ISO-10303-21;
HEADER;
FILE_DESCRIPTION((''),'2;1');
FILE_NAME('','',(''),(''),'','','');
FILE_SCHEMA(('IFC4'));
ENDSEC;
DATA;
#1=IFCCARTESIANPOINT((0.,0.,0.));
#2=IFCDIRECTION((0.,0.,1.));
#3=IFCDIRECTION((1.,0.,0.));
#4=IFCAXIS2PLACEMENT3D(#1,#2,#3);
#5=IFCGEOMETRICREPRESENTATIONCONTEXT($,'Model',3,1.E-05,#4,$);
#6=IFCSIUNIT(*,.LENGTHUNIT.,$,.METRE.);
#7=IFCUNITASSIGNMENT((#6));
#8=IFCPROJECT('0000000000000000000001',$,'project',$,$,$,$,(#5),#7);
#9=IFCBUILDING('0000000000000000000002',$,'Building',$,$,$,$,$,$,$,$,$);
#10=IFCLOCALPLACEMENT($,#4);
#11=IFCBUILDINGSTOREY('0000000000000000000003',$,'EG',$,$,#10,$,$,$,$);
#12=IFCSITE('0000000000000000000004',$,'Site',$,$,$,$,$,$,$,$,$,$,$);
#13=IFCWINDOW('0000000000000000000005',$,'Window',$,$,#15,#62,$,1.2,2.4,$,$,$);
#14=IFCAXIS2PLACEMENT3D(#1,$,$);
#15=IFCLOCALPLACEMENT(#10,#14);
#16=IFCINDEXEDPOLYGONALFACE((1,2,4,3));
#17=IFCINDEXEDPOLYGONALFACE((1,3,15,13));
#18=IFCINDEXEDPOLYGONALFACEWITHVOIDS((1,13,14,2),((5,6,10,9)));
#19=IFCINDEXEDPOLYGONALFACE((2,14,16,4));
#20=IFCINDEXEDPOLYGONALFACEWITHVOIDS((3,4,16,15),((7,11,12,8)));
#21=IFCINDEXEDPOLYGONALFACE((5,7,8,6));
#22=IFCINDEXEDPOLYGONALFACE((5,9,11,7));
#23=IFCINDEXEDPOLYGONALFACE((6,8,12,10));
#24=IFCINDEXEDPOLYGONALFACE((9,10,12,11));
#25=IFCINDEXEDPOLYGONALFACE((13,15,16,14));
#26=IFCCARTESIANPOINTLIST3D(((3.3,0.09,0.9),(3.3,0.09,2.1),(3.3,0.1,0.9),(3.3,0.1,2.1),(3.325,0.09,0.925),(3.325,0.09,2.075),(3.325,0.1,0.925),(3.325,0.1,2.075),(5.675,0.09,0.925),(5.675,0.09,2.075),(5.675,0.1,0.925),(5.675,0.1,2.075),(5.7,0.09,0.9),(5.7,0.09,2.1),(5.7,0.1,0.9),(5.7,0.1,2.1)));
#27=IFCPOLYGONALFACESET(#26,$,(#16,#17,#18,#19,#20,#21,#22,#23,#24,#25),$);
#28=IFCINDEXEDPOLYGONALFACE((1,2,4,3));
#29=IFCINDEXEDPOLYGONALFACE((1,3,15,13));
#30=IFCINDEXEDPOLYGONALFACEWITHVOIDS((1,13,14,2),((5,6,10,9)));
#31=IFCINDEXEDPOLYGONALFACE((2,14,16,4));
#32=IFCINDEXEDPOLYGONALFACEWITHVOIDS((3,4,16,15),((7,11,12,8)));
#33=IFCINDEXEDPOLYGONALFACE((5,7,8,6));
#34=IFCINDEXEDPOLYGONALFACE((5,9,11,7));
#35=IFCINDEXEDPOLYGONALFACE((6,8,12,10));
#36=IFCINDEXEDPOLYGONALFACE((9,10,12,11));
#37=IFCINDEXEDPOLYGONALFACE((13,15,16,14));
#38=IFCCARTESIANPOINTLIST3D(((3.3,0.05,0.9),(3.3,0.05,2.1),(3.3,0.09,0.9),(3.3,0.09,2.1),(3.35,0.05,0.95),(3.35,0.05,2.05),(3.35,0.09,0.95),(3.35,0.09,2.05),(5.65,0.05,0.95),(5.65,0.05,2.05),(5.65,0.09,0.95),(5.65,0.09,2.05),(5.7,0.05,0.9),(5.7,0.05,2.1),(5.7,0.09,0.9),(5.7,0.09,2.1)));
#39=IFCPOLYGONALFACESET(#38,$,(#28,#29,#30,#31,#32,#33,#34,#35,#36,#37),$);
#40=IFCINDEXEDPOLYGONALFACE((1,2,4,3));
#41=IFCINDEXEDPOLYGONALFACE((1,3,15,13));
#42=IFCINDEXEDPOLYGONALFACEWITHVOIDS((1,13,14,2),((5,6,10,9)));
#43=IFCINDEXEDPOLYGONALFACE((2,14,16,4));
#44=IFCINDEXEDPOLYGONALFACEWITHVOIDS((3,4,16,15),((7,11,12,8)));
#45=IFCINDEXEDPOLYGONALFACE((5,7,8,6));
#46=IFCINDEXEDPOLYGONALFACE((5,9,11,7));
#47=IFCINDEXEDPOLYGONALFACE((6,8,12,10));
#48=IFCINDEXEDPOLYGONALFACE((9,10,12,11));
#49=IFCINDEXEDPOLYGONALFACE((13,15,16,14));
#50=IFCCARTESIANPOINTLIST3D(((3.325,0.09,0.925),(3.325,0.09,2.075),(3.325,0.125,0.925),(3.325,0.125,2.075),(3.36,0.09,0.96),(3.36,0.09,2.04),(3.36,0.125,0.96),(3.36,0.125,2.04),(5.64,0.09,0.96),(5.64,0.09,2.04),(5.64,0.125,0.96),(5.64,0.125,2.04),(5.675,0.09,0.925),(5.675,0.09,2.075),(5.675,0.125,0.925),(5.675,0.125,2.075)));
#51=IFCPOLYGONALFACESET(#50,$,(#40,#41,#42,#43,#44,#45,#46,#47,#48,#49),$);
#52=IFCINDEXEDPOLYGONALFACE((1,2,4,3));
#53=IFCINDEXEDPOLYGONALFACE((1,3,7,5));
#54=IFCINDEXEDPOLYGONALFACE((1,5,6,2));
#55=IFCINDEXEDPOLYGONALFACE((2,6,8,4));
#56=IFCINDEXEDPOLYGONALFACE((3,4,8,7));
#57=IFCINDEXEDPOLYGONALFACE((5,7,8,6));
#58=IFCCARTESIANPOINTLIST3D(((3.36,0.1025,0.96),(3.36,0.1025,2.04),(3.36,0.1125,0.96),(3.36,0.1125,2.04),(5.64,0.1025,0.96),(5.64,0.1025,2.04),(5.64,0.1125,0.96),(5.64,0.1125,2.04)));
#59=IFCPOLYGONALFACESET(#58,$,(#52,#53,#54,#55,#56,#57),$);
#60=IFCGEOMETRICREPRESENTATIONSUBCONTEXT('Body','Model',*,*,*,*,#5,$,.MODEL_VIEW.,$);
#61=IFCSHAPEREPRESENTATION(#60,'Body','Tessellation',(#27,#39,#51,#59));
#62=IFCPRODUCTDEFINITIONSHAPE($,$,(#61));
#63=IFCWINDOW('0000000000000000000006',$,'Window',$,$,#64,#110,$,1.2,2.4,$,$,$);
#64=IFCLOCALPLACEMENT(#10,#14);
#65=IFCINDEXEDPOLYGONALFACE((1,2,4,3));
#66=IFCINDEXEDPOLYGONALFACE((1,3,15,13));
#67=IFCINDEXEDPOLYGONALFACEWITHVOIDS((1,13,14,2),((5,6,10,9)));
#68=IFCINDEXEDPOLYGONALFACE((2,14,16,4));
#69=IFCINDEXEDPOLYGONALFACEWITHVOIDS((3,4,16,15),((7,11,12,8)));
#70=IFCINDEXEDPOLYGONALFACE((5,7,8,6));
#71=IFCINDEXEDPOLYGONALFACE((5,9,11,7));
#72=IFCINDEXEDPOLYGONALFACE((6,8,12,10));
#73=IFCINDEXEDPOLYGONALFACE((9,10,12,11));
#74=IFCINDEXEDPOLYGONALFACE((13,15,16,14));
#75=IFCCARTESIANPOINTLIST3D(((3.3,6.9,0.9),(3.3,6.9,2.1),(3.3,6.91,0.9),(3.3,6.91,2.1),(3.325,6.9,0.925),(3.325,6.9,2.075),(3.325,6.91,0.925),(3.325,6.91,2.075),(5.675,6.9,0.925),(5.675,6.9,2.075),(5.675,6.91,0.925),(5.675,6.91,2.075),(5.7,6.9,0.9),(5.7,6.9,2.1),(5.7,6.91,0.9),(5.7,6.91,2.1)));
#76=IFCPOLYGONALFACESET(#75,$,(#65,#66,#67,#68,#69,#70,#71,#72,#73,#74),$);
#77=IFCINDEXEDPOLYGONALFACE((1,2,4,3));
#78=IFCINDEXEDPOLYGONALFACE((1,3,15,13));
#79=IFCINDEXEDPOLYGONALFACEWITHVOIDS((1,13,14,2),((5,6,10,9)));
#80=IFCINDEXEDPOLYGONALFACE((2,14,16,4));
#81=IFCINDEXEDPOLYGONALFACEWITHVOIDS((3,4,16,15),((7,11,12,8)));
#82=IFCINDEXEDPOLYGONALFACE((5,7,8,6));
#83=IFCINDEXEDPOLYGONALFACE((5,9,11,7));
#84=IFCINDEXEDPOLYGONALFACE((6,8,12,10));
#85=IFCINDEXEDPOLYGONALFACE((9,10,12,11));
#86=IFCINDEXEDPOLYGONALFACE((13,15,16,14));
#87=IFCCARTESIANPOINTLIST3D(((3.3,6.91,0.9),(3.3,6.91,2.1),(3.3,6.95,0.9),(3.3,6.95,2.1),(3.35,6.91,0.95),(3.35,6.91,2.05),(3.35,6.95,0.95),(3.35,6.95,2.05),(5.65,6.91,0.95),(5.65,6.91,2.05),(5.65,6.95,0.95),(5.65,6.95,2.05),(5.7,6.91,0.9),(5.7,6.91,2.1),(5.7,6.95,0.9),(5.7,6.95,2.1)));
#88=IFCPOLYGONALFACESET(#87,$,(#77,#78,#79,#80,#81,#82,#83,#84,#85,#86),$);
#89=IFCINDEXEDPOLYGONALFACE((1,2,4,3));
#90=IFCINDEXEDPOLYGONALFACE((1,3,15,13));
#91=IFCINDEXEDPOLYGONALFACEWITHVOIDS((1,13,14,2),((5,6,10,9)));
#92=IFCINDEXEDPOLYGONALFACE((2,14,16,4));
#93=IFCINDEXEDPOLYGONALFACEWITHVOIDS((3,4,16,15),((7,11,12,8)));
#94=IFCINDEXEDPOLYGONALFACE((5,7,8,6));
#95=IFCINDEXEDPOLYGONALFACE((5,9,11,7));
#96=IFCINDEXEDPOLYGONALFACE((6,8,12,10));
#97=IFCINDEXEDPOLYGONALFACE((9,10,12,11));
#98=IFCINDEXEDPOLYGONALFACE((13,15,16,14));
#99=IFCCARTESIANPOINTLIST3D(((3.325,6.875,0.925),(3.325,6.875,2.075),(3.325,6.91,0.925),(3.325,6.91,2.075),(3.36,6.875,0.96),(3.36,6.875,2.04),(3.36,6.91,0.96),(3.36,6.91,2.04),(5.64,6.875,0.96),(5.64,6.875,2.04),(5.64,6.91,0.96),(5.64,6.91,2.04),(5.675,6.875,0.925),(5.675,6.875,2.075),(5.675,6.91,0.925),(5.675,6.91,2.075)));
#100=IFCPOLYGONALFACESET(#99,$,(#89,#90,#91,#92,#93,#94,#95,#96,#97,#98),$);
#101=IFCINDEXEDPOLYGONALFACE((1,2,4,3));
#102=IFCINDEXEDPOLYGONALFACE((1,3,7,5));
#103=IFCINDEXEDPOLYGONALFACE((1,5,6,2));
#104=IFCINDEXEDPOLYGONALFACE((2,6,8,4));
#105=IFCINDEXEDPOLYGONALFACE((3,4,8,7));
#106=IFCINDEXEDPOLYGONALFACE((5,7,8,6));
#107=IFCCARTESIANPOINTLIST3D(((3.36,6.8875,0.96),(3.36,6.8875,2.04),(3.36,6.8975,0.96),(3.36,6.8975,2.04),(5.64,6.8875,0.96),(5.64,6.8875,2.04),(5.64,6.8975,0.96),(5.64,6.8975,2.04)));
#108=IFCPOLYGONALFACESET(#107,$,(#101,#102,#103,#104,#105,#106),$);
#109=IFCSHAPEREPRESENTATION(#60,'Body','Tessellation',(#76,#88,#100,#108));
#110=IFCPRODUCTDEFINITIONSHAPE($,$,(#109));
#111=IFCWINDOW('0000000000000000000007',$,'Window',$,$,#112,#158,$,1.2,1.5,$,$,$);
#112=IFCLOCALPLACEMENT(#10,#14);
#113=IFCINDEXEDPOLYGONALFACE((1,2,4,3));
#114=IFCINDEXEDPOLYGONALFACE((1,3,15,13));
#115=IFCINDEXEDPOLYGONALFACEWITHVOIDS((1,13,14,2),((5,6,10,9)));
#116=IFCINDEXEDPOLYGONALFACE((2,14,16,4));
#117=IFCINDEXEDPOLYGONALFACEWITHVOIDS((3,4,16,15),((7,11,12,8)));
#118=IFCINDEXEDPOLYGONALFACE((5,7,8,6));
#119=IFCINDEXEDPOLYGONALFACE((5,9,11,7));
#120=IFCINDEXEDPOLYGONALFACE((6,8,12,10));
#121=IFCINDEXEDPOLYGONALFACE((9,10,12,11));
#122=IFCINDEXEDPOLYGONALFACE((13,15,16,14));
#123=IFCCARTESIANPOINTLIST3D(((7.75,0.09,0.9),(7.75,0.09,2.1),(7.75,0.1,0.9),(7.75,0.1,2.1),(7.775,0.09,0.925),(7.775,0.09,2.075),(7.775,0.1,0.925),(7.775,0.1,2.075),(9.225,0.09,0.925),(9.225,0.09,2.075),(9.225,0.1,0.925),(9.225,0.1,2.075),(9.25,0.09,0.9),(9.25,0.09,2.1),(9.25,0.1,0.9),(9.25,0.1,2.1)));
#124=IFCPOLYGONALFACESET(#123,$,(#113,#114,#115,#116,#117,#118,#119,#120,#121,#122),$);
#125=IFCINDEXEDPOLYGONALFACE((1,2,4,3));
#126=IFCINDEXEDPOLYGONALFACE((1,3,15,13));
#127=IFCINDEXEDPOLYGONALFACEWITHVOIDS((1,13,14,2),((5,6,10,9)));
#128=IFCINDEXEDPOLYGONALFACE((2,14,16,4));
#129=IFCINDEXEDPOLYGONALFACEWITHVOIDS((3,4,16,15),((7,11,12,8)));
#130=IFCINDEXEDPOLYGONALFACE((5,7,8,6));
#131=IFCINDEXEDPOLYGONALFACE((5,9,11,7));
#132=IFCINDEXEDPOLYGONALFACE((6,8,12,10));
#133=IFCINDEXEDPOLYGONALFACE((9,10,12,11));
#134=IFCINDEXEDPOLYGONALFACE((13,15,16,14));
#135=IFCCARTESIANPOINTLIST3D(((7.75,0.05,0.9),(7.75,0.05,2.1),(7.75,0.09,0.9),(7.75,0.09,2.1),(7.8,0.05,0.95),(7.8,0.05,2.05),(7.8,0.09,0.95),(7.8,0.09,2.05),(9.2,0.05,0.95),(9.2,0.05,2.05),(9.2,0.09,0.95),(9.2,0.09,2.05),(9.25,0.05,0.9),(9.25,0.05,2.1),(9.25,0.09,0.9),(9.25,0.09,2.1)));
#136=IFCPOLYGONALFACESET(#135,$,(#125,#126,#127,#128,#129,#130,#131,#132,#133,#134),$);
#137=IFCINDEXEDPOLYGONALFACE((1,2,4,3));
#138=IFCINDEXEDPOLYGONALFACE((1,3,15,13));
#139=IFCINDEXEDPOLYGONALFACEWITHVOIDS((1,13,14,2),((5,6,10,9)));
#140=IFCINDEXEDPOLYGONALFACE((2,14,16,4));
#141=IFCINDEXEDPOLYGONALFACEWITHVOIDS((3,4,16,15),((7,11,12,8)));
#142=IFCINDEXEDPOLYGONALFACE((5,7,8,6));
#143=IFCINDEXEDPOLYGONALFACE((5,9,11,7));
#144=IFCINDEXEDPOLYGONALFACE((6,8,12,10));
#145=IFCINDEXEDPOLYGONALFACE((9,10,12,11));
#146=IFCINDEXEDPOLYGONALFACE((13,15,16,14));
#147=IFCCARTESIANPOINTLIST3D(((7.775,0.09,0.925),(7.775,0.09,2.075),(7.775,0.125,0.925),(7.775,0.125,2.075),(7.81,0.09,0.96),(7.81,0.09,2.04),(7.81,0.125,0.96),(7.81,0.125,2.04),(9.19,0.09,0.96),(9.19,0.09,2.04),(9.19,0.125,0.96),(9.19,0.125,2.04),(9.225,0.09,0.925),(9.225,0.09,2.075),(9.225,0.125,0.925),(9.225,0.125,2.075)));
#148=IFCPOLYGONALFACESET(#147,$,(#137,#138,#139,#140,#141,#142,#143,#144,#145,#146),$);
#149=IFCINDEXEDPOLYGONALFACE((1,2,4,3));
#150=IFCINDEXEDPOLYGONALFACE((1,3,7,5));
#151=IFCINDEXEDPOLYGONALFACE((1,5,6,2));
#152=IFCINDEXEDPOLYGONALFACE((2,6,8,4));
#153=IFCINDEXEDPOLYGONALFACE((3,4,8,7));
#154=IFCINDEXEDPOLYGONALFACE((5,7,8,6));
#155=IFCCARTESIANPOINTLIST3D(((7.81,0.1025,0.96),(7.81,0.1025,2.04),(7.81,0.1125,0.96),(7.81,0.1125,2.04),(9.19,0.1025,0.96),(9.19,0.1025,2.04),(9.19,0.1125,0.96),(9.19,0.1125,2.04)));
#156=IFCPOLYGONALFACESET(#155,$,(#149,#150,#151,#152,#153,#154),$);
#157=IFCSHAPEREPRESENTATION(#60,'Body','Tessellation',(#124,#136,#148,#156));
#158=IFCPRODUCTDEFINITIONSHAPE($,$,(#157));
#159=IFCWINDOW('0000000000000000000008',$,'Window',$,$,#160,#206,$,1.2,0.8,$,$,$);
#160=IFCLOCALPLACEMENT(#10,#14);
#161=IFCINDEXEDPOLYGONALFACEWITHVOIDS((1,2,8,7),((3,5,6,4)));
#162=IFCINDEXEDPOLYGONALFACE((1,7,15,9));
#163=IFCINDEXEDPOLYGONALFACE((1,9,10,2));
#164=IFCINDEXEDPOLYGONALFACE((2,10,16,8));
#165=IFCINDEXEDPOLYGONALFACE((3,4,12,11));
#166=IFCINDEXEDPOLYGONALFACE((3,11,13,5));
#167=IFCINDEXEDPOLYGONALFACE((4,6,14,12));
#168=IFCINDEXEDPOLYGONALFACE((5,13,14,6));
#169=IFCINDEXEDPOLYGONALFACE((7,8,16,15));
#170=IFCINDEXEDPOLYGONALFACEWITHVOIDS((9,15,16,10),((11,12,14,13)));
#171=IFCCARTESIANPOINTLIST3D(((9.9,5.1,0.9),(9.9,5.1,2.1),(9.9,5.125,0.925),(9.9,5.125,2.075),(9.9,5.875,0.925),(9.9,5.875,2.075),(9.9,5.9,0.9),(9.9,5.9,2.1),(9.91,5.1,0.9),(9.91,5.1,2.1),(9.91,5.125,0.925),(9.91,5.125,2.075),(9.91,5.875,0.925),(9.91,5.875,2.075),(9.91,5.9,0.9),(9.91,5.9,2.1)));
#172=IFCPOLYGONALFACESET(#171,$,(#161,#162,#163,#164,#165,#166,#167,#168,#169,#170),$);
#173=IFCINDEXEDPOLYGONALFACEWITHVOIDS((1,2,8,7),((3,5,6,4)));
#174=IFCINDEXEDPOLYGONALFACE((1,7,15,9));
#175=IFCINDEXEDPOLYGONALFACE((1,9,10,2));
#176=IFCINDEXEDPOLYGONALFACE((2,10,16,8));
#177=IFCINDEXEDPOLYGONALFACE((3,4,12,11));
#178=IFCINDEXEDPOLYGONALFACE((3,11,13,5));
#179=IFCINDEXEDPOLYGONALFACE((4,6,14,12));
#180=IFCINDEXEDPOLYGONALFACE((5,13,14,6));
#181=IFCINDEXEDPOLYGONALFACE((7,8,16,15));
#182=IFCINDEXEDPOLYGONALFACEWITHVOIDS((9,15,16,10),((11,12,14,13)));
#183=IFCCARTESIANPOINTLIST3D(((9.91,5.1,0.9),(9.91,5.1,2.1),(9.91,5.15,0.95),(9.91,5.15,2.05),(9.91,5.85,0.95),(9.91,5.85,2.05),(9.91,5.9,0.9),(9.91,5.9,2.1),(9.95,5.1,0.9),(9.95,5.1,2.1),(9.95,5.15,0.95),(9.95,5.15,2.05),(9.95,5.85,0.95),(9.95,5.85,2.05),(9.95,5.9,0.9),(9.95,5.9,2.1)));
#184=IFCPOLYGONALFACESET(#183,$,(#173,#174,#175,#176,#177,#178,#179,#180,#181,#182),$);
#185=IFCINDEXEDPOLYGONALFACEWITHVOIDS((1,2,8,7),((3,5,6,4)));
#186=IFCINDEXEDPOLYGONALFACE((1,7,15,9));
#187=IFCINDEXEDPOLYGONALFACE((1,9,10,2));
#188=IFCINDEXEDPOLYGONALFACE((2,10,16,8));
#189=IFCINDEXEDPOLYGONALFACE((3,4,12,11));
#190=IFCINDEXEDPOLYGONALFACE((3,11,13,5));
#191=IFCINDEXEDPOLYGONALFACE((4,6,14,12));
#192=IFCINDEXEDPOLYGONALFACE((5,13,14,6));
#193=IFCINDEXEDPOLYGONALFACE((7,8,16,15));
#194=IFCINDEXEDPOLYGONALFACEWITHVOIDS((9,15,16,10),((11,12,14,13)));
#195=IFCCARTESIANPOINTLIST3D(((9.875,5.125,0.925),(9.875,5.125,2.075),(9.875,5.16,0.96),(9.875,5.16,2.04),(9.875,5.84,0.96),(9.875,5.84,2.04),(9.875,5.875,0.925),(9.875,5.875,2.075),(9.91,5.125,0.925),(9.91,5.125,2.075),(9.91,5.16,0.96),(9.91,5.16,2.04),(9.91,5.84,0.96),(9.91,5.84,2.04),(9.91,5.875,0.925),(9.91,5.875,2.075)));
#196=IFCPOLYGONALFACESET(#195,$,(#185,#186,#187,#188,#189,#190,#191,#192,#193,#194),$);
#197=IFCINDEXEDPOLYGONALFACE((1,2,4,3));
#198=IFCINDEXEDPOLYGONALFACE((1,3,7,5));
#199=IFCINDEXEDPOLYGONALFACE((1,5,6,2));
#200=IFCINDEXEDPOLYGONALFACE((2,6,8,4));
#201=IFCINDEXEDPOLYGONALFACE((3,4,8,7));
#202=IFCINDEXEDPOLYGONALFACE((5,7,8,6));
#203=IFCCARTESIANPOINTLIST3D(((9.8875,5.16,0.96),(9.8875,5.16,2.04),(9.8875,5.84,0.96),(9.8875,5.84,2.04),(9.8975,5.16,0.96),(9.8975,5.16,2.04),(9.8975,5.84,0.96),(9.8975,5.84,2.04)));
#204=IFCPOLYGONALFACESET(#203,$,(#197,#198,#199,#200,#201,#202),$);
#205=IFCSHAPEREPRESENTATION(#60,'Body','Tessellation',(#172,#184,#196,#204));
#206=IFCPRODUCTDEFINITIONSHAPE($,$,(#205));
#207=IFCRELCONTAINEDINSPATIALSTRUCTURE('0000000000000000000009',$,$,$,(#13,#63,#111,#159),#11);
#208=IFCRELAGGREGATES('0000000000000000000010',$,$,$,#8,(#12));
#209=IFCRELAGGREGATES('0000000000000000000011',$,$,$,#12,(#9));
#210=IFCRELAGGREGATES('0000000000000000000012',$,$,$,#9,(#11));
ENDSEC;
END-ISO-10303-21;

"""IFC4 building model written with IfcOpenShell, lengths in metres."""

from ifc_helpers import new_model, si_unit, frame, origin_with_axes, place, context, subcontext, project, spatial, line, indexed_curve, outline, extrude, element, save


model = new_model("IFC4")

# Units and contexts
model_context = context("Model", 3, precision=1e-05, world=origin_with_axes())
body_context = subcontext(model_context, "Body", "Model", "MODEL_VIEW")
ifc_project = project(units=[si_unit("LENGTHUNIT", "METRE")], contexts=[model_context])

# Site, building, storey
site = spatial("IfcSite", under=ifc_project, Name="Site")
building = spatial("IfcBuilding", under=site, Name="Building")
storey_placement = place(None, origin_with_axes())
storey = spatial("IfcBuildingStorey", under=building, at=storey_placement, Name="EG")

# Windows
for number, where, z_axis, x_axis, name in (
    (1, (3.3, 0.0, 0.9), (0.0, 0.0, 1.0), (1.0, 0.0, 0.0), "Window"),
    (2, (5.7, 7.0, 0.9), (0.0, 0.0, 1.0), (-1.0, 0.0, 0.0), "Window"),
):
    element("IfcWindow", number, at=place(storey_placement, frame(where, z_axis=z_axis, x_axis=x_axis)), inside=storey, Name=name, OverallHeight=1.2, OverallWidth=2.4, context=body_context, shape_type="SweptSolid", body=[
        extrude(outline(indexed_curve([(0.0, 0.0), (2.4, 0.0), (2.4, 1.2), (0.0, 1.2)], segments=[line(1, 2, 3, 4, 1)]), holes=[indexed_curve([(0.025, 0.025), (2.375, 0.025), (2.375, 1.175), (0.025, 1.175)], segments=[line(1, 2, 3, 4, 1)])]), frame((0.0, 0.09, 0.0), z_axis=(0.0, -1.0, 0.0), x_axis=(1.0, 0.0, 0.0)), (0.0, 0.0, -1.0), 0.01),
        extrude(outline(indexed_curve([(0.0, 0.0), (2.4, 0.0), (2.4, 1.2), (0.0, 1.2)], segments=[line(1, 2, 3, 4, 1)]), holes=[indexed_curve([(0.05, 0.05), (2.35, 0.05), (2.35, 1.15), (0.05, 1.15)], segments=[line(1, 2, 3, 4, 1)])]), frame((0.0, 0.05, 0.0), z_axis=(0.0, -1.0, 0.0), x_axis=(1.0, 0.0, 0.0)), (0.0, 0.0, -1.0), 0.04),
        extrude(outline(indexed_curve([(0.0, 0.0), (2.35, 0.0), (2.35, 1.15), (0.0, 1.15)], segments=[line(1, 2, 3, 4, 1)]), holes=[indexed_curve([(0.035, 0.035), (2.315, 0.035), (2.315, 1.115), (0.035, 1.115)], segments=[line(1, 2, 3, 4, 1)])]), frame((0.025, 0.09, 0.025), z_axis=(0.0, -1.0, 0.0), x_axis=(1.0, 0.0, 0.0)), (0.0, 0.0, -1.0), 0.035),
        extrude(outline(indexed_curve([(0.035, 0.035), (2.315, 0.035), (2.315, 1.115), (0.035, 1.115)], segments=[line(1, 2, 3, 4, 1)])), frame((0.025, 0.1025, 0.025), z_axis=(0.0, -1.0, 0.0), x_axis=(1.0, 0.0, 0.0)), (0.0, 0.0, -1.0), 0.01),
    ])
window_placement = place(storey_placement, frame((7.75, 0.0, 0.9), z_axis=(0.0, 0.0, 1.0), x_axis=(1.0, 0.0, 0.0)))
element("IfcWindow", 3, at=window_placement, inside=storey, Name="Window", OverallHeight=1.2, OverallWidth=1.5, context=body_context, shape_type="SweptSolid", body=[
    extrude(outline(indexed_curve([(0.0, 0.0), (1.5, 0.0), (1.5, 1.2), (0.0, 1.2)], segments=[line(1, 2, 3, 4, 1)]), holes=[indexed_curve([(0.025, 0.025), (1.475, 0.025), (1.475, 1.175), (0.025, 1.175)], segments=[line(1, 2, 3, 4, 1)])]), frame((0.0, 0.09, 0.0), z_axis=(0.0, -1.0, 0.0), x_axis=(1.0, 0.0, 0.0)), (0.0, 0.0, -1.0), 0.01),
    extrude(outline(indexed_curve([(0.0, 0.0), (1.5, 0.0), (1.5, 1.2), (0.0, 1.2)], segments=[line(1, 2, 3, 4, 1)]), holes=[indexed_curve([(0.05, 0.05), (1.45, 0.05), (1.45, 1.15), (0.05, 1.15)], segments=[line(1, 2, 3, 4, 1)])]), frame((0.0, 0.05, 0.0), z_axis=(0.0, -1.0, 0.0), x_axis=(1.0, 0.0, 0.0)), (0.0, 0.0, -1.0), 0.04),
    extrude(outline(indexed_curve([(0.0, 0.0), (1.45, 0.0), (1.45, 1.15), (0.0, 1.15)], segments=[line(1, 2, 3, 4, 1)]), holes=[indexed_curve([(0.035, 0.035), (1.415, 0.035), (1.415, 1.115), (0.035, 1.115)], segments=[line(1, 2, 3, 4, 1)])]), frame((0.025, 0.09, 0.025), z_axis=(0.0, -1.0, 0.0), x_axis=(1.0, 0.0, 0.0)), (0.0, 0.0, -1.0), 0.035),
    extrude(outline(indexed_curve([(0.035, 0.035), (1.415, 0.035), (1.415, 1.115), (0.035, 1.115)], segments=[line(1, 2, 3, 4, 1)])), frame((0.025, 0.1025, 0.025), z_axis=(0.0, -1.0, 0.0), x_axis=(1.0, 0.0, 0.0)), (0.0, 0.0, -1.0), 0.01),
])
for number, where, z_axis, x_axis, name in (
    (4, (10.0, 5.1, 0.9), (0.0, 0.0, 1.0), (0.0, 1.0, 0.0), "Window"),
):
    element("IfcWindow", number, at=place(storey_placement, frame(where, z_axis=z_axis, x_axis=x_axis)), inside=storey, Name=name, OverallHeight=1.2, OverallWidth=0.8, context=body_context, shape_type="SweptSolid", body=[
        extrude(outline(indexed_curve([(0.0, 0.0), (0.8, 0.0), (0.8, 1.2), (0.0, 1.2)], segments=[line(1, 2, 3, 4, 1)]), holes=[indexed_curve([(0.025, 0.025), (0.775, 0.025), (0.775, 1.175), (0.025, 1.175)], segments=[line(1, 2, 3, 4, 1)])]), frame((0.0, 0.09, 0.0), z_axis=(0.0, -1.0, 0.0), x_axis=(1.0, 0.0, 0.0)), (0.0, 0.0, -1.0), 0.01),
        extrude(outline(indexed_curve([(0.0, 0.0), (0.8, 0.0), (0.8, 1.2), (0.0, 1.2)], segments=[line(1, 2, 3, 4, 1)]), holes=[indexed_curve([(0.05, 0.05), (0.75, 0.05), (0.75, 1.15), (0.05, 1.15)], segments=[line(1, 2, 3, 4, 1)])]), frame((0.0, 0.05, 0.0), z_axis=(0.0, -1.0, 0.0), x_axis=(1.0, 0.0, 0.0)), (0.0, 0.0, -1.0), 0.04),
        extrude(outline(indexed_curve([(0.0, 0.0), (0.75, 0.0), (0.75, 1.15), (0.0, 1.15)], segments=[line(1, 2, 3, 4, 1)]), holes=[indexed_curve([(0.035, 0.035), (0.715, 0.035), (0.715, 1.115), (0.035, 1.115)], segments=[line(1, 2, 3, 4, 1)])]), frame((0.025, 0.09, 0.025), z_axis=(0.0, -1.0, 0.0), x_axis=(1.0, 0.0, 0.0)), (0.0, 0.0, -1.0), 0.035),
        extrude(outline(indexed_curve([(0.035, 0.035), (0.715, 0.035), (0.715, 1.115), (0.035, 1.115)], segments=[line(1, 2, 3, 4, 1)])), frame((0.025, 0.1025, 0.025), z_axis=(0.0, -1.0, 0.0), x_axis=(1.0, 0.0, 0.0)), (0.0, 0.0, -1.0), 0.01),
    ])

save(model, "model.ifc")
